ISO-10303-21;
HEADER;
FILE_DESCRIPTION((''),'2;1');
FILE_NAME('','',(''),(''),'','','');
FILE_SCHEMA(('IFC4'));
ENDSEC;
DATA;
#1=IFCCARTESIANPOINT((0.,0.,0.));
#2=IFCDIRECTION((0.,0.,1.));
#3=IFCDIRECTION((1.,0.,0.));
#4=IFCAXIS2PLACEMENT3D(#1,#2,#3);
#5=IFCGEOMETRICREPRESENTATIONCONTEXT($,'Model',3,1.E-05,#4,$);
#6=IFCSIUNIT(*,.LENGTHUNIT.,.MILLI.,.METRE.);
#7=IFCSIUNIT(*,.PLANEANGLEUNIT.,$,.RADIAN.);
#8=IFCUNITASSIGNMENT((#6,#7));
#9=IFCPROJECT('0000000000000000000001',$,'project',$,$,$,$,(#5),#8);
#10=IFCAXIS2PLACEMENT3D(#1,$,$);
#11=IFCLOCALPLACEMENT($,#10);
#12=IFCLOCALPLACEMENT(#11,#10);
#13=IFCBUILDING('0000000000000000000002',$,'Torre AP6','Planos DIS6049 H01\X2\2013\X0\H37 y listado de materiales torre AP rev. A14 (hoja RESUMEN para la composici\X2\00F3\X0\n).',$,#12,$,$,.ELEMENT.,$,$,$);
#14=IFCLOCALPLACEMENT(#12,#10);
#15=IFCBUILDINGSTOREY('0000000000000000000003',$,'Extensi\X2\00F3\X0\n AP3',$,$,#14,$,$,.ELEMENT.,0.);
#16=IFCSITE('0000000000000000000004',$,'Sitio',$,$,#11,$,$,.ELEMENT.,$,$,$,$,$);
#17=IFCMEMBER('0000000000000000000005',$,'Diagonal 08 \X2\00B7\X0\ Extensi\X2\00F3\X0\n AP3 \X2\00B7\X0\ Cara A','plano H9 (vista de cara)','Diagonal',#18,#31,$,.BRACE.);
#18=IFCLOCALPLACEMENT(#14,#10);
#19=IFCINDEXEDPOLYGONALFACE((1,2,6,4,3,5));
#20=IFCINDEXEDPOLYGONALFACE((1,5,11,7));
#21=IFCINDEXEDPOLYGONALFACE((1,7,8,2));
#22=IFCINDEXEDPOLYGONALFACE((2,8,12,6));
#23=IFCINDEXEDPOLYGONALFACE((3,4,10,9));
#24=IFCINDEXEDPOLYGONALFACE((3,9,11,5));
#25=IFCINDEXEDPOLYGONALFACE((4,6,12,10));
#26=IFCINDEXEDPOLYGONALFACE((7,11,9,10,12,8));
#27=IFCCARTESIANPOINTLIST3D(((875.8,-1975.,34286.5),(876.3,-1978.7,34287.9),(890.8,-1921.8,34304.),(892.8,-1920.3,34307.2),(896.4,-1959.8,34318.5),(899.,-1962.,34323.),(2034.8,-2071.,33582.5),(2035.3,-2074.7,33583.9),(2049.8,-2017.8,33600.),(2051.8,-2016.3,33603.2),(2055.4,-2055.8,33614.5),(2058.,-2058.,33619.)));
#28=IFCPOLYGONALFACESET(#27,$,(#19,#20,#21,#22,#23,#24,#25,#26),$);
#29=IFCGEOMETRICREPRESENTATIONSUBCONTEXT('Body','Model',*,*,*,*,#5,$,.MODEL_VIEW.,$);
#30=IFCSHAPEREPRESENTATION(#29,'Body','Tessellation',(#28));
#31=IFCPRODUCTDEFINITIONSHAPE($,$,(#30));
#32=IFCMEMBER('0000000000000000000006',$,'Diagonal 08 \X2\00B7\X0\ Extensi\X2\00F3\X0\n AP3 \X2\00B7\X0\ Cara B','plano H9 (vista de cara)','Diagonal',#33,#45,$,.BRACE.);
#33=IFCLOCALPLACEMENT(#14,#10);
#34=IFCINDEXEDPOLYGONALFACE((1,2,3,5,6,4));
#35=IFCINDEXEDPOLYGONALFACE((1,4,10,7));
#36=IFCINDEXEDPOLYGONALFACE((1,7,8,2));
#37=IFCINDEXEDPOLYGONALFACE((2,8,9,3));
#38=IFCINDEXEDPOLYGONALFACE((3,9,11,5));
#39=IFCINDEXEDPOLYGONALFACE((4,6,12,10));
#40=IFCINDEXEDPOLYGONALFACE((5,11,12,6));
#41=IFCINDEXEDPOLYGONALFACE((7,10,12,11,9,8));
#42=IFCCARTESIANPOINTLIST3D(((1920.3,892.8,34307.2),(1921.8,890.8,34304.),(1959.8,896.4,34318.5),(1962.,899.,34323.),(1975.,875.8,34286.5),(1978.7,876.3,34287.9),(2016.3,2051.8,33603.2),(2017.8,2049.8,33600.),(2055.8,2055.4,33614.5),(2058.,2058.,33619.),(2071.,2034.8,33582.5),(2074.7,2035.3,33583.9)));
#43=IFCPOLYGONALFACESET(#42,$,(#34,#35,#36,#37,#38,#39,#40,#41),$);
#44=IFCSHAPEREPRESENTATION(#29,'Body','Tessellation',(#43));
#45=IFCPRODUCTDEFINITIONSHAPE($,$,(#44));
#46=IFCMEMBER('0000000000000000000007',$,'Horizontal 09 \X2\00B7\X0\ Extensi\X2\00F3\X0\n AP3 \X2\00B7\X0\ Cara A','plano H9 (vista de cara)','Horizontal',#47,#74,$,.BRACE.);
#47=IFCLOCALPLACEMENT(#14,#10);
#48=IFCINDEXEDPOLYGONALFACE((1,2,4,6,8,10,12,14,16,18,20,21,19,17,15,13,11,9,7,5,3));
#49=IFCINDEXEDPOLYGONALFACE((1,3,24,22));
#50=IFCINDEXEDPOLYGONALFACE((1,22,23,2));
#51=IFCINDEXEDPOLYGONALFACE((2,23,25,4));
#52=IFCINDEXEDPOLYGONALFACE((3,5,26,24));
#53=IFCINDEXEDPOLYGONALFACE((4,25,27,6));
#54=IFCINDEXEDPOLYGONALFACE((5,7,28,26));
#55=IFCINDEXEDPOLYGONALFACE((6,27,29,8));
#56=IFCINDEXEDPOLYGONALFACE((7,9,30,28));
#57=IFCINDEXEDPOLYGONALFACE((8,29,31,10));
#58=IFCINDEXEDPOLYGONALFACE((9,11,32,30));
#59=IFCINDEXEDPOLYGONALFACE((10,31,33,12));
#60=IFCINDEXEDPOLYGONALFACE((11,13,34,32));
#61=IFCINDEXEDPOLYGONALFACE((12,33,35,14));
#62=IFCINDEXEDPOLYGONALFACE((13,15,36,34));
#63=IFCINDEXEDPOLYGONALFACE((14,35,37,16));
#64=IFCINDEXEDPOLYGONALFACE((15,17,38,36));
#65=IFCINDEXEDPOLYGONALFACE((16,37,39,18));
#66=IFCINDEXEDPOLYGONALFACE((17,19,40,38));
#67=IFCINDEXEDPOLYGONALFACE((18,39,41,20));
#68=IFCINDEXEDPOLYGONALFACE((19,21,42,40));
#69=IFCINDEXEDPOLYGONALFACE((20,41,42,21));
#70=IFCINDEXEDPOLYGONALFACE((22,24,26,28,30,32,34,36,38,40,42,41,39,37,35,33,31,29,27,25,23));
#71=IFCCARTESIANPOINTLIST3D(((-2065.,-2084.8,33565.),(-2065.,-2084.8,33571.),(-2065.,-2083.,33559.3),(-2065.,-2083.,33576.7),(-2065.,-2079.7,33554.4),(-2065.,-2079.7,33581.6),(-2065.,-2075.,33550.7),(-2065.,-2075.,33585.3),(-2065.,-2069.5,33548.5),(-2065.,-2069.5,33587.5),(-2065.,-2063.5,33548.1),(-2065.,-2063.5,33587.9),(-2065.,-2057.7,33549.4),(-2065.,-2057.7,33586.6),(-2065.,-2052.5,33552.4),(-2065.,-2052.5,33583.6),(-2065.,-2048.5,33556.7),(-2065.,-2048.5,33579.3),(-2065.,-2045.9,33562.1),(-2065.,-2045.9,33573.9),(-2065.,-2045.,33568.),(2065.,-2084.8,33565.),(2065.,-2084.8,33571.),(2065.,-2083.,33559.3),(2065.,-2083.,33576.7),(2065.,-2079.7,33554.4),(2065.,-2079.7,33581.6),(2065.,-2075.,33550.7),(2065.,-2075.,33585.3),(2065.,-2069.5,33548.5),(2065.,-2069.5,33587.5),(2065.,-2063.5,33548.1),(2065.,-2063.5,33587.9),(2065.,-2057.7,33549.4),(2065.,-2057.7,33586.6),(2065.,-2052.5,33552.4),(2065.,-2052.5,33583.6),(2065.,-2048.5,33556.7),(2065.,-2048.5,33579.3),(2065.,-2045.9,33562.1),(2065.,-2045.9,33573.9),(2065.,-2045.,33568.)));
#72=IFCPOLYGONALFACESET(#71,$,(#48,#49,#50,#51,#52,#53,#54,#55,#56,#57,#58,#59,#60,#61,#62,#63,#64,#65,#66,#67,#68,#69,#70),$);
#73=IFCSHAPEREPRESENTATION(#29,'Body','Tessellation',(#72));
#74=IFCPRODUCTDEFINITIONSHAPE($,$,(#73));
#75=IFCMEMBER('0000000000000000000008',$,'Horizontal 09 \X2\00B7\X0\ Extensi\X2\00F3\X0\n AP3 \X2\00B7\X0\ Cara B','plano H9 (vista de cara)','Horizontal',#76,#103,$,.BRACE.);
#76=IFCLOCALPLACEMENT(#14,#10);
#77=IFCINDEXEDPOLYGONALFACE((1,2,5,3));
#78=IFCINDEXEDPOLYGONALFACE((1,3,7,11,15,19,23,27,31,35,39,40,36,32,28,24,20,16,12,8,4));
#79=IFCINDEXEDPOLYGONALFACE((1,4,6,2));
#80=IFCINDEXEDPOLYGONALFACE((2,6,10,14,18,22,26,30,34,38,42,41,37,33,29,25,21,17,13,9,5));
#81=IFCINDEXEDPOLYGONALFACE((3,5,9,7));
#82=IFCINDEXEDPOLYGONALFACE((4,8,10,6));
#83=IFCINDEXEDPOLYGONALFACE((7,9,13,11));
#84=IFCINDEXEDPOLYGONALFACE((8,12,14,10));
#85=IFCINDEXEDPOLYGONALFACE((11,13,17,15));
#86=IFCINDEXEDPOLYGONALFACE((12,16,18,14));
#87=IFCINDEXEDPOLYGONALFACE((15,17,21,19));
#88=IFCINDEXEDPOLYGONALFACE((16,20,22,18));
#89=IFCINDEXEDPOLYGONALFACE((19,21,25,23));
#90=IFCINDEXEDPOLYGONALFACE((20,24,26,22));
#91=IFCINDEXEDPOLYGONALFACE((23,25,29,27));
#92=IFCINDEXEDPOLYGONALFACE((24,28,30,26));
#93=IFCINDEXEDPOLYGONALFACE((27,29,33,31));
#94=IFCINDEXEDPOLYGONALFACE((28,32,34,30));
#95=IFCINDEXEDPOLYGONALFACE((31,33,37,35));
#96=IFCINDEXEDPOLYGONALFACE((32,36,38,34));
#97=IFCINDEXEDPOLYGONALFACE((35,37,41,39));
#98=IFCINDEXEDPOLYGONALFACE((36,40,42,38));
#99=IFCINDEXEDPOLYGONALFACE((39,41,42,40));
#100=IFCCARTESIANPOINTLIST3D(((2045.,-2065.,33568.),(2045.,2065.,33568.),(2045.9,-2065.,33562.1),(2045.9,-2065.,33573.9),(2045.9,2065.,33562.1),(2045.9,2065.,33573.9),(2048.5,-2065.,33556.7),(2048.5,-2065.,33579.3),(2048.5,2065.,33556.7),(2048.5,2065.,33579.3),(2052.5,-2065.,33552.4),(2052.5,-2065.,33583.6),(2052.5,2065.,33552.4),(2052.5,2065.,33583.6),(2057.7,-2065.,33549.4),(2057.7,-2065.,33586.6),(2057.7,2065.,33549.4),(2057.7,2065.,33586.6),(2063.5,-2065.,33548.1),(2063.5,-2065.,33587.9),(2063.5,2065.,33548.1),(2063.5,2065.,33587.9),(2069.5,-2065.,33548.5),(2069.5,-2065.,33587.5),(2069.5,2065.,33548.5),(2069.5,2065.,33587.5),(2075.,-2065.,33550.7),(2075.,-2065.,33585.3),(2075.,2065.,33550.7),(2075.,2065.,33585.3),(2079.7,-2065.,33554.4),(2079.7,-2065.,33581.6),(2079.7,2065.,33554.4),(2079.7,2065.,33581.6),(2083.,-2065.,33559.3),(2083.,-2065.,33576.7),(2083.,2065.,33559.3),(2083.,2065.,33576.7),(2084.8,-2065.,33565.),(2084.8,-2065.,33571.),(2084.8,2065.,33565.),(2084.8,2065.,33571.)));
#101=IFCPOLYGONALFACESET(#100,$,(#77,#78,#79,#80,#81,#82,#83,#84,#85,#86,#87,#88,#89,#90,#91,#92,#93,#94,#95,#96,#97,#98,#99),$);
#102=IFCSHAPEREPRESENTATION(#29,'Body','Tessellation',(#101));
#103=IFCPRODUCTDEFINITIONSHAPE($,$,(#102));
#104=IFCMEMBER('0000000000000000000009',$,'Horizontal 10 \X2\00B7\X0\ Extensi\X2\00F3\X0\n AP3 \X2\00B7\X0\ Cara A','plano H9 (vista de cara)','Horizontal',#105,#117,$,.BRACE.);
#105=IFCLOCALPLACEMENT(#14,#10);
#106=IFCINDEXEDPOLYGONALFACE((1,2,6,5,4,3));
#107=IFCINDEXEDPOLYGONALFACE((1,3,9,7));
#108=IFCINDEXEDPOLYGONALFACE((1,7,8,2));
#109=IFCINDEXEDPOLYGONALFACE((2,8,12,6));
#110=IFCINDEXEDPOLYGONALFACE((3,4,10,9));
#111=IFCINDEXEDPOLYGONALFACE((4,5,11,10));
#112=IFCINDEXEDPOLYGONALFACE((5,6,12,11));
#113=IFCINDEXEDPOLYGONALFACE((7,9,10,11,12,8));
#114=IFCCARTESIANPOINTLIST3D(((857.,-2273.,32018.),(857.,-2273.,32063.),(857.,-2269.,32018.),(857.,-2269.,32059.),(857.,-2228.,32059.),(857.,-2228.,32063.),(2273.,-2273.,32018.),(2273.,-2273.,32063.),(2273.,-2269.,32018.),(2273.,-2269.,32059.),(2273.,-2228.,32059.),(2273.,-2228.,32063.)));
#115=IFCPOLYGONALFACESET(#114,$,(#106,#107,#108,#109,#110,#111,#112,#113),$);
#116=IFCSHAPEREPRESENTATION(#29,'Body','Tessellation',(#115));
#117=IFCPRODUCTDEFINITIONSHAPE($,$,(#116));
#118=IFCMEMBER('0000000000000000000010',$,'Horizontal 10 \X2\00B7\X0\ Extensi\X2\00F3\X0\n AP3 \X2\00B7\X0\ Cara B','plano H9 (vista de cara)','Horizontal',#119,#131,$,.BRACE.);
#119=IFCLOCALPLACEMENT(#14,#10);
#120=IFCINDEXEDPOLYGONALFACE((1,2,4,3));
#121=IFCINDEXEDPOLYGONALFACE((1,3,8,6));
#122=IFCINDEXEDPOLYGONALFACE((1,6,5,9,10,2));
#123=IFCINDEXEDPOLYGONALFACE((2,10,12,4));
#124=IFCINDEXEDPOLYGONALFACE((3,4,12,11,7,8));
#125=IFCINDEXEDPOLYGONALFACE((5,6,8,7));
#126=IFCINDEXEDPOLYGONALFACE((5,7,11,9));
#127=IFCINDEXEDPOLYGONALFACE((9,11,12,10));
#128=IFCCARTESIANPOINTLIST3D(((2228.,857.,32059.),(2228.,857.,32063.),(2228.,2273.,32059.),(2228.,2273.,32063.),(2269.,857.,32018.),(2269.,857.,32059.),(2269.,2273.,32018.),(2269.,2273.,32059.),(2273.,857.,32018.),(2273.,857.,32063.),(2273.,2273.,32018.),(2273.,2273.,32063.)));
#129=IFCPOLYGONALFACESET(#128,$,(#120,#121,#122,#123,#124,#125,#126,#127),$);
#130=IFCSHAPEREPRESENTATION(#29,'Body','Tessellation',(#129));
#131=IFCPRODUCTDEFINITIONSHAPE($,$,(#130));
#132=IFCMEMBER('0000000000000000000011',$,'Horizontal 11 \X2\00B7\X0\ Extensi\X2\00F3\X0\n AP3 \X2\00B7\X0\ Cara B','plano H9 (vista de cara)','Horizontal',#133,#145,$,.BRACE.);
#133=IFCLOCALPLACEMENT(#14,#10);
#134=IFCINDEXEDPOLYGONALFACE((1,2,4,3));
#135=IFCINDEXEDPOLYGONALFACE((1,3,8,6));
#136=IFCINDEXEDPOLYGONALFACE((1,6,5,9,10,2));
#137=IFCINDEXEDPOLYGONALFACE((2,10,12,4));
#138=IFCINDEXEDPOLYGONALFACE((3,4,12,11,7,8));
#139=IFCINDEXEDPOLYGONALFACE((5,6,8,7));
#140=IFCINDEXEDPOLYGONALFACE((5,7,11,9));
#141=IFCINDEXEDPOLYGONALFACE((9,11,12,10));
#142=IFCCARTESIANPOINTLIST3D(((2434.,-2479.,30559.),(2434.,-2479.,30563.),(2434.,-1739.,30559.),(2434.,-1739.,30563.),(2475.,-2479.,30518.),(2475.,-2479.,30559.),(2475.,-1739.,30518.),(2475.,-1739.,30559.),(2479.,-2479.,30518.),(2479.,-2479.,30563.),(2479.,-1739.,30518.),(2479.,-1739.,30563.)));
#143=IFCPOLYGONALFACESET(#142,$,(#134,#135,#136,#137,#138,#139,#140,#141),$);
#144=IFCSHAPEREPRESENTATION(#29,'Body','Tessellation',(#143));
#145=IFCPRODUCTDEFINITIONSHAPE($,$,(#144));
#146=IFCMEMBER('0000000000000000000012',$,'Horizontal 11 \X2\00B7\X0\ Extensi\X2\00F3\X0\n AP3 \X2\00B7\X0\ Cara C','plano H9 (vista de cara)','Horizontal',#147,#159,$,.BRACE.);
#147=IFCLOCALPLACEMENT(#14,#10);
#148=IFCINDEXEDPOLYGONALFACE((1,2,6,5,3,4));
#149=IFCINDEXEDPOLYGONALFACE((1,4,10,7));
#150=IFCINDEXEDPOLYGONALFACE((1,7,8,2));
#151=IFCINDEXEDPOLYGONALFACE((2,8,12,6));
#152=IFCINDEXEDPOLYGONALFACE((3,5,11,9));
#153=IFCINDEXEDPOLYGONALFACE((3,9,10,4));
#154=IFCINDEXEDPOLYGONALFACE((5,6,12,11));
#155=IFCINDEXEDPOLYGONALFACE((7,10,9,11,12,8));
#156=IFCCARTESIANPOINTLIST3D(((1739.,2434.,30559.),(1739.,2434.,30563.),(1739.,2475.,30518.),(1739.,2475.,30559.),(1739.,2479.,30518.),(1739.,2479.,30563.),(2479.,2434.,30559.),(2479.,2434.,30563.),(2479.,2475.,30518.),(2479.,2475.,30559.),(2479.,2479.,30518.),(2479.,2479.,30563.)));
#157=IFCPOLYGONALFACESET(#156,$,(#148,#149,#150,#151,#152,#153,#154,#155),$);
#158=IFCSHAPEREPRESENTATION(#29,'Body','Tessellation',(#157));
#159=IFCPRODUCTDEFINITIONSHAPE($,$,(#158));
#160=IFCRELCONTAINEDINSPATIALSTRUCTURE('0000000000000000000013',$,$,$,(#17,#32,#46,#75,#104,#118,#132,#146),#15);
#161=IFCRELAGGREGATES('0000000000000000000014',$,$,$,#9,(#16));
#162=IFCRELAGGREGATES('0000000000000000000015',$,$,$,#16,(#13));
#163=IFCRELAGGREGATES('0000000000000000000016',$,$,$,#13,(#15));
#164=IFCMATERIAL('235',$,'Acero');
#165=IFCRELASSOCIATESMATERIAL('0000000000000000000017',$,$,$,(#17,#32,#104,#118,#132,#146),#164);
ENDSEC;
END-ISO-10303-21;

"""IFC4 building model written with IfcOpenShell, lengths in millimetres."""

from ifc_helpers import new_model, si_unit, frame, frame_2d, origin, origin_with_axes, place, context, subcontext, project, spatial, circle, l_section, extrude, material, element, save


model = new_model("IFC4")

# Units and contexts
model_context = context("Model", 3, precision=1e-05, world=origin_with_axes())
body_context = subcontext(model_context, "Body", "Model", "MODEL_VIEW")
ifc_project = project(units=[si_unit("LENGTHUNIT", "METRE", prefix="MILLI"), si_unit("PLANEANGLEUNIT", "RADIAN")], contexts=[model_context])

# Site, building, storey
site_placement = place(None, origin())
site = spatial("IfcSite", under=ifc_project, at=site_placement, Name="Sitio", CompositionType="ELEMENT")
building_placement = place(site_placement, origin())
building = spatial("IfcBuilding", under=site, at=building_placement, Name="Torre AP6", Description="Planos DIS6049 H01–H37 y listado de materiales torre AP rev. A14 (hoja RESUMEN para la composición).", CompositionType="ELEMENT")
storey_placement = place(building_placement, origin())
storey = spatial("IfcBuildingStorey", under=building, at=storey_placement, Name="Extensión AP3", CompositionType="ELEMENT", Elevation=0.0)

# Members
ifc_material_1 = material(Name="235", Category="Acero")
for number, where, z_axis, x_axis, name in (
    (1, (2058.0, -2058.0, 33619.0), (-0.852549, 0.070617, 0.517855), (-0.137057, 0.925948, -0.351904), "Diagonal 08 · Extensión AP3 · Cara A"),
    (2, (2058.0, 2058.0, 33619.0), (-0.070617, -0.852549, 0.517855), (-0.925948, -0.137057, -0.351904), "Diagonal 08 · Extensión AP3 · Cara B"),
):
    element("IfcMember", number, at=place(storey_placement, frame(where, z_axis=z_axis, x_axis=x_axis)), inside=storey, material=ifc_material_1, Name=name, Description="plano H9 (vista de cara)", ObjectType="Diagonal", PredefinedType="BRACE", context=body_context, shape_type="SweptSolid", body=[
        extrude(l_section(Depth=45.0, Width=45.0, Thickness=4.0, at=frame_2d((22.5, 22.5))), None, (0.0, 0.0, 1.0), 1359.5),
    ])
for number, where, z_axis, x_axis, name in (
    (3, (2065.0, -2065.0, 33568.0), (-1.0, 0.0, 0.0), (0.0, 1.0, 0.0), "Horizontal 09 · Extensión AP3 · Cara A"),
    (4, (2065.0, 2065.0, 33568.0), (0.0, -1.0, 0.0), (-1.0, 0.0, 0.0), "Horizontal 09 · Extensión AP3 · Cara B"),
):
    element("IfcMember", number, at=place(storey_placement, frame(where, z_axis=z_axis, x_axis=x_axis)), inside=storey, Name=name, Description="plano H9 (vista de cara)", ObjectType="Horizontal", PredefinedType="BRACE", context=body_context, shape_type="SweptSolid", body=[
        extrude(circle(Radius=20.0), None, (0.0, 0.0, 1.0), 4130.0),
    ])
for number, where, z_axis, x_axis, name in (
    (5, (2273.0, -2273.0, 32063.0), (-1.0, 0.0, 0.0), (0.0, 1.0, 0.0), "Horizontal 10 · Extensión AP3 · Cara A"),
    (6, (2273.0, 2273.0, 32063.0), (0.0, -1.0, 0.0), (-1.0, 0.0, 0.0), "Horizontal 10 · Extensión AP3 · Cara B"),
):
    element("IfcMember", number, at=place(storey_placement, frame(where, z_axis=z_axis, x_axis=x_axis)), inside=storey, material=ifc_material_1, Name=name, Description="plano H9 (vista de cara)", ObjectType="Horizontal", PredefinedType="BRACE", context=body_context, shape_type="SweptSolid", body=[
        extrude(l_section(Depth=45.0, Width=45.0, Thickness=4.0, at=frame_2d((22.5, 22.5))), None, (0.0, 0.0, 1.0), 1416.0),
    ])
for number, where, z_axis, x_axis, name in (
    (7, (2479.0, -1739.0, 30563.0), (0.0, -1.0, 0.0), (-1.0, 0.0, 0.0), "Horizontal 11 · Extensión AP3 · Cara B"),
    (8, (1739.0, 2479.0, 30563.0), (1.0, 0.0, 0.0), (0.0, -1.0, 0.0), "Horizontal 11 · Extensión AP3 · Cara C"),
):
    element("IfcMember", number, at=place(storey_placement, frame(where, z_axis=z_axis, x_axis=x_axis)), inside=storey, material=ifc_material_1, Name=name, Description="plano H9 (vista de cara)", ObjectType="Horizontal", PredefinedType="BRACE", context=body_context, shape_type="SweptSolid", body=[
        extrude(l_section(Depth=45.0, Width=45.0, Thickness=4.0, at=frame_2d((22.5, 22.5))), None, (0.0, 0.0, 1.0), 740.0),
    ])

save(model, "model.ifc")
